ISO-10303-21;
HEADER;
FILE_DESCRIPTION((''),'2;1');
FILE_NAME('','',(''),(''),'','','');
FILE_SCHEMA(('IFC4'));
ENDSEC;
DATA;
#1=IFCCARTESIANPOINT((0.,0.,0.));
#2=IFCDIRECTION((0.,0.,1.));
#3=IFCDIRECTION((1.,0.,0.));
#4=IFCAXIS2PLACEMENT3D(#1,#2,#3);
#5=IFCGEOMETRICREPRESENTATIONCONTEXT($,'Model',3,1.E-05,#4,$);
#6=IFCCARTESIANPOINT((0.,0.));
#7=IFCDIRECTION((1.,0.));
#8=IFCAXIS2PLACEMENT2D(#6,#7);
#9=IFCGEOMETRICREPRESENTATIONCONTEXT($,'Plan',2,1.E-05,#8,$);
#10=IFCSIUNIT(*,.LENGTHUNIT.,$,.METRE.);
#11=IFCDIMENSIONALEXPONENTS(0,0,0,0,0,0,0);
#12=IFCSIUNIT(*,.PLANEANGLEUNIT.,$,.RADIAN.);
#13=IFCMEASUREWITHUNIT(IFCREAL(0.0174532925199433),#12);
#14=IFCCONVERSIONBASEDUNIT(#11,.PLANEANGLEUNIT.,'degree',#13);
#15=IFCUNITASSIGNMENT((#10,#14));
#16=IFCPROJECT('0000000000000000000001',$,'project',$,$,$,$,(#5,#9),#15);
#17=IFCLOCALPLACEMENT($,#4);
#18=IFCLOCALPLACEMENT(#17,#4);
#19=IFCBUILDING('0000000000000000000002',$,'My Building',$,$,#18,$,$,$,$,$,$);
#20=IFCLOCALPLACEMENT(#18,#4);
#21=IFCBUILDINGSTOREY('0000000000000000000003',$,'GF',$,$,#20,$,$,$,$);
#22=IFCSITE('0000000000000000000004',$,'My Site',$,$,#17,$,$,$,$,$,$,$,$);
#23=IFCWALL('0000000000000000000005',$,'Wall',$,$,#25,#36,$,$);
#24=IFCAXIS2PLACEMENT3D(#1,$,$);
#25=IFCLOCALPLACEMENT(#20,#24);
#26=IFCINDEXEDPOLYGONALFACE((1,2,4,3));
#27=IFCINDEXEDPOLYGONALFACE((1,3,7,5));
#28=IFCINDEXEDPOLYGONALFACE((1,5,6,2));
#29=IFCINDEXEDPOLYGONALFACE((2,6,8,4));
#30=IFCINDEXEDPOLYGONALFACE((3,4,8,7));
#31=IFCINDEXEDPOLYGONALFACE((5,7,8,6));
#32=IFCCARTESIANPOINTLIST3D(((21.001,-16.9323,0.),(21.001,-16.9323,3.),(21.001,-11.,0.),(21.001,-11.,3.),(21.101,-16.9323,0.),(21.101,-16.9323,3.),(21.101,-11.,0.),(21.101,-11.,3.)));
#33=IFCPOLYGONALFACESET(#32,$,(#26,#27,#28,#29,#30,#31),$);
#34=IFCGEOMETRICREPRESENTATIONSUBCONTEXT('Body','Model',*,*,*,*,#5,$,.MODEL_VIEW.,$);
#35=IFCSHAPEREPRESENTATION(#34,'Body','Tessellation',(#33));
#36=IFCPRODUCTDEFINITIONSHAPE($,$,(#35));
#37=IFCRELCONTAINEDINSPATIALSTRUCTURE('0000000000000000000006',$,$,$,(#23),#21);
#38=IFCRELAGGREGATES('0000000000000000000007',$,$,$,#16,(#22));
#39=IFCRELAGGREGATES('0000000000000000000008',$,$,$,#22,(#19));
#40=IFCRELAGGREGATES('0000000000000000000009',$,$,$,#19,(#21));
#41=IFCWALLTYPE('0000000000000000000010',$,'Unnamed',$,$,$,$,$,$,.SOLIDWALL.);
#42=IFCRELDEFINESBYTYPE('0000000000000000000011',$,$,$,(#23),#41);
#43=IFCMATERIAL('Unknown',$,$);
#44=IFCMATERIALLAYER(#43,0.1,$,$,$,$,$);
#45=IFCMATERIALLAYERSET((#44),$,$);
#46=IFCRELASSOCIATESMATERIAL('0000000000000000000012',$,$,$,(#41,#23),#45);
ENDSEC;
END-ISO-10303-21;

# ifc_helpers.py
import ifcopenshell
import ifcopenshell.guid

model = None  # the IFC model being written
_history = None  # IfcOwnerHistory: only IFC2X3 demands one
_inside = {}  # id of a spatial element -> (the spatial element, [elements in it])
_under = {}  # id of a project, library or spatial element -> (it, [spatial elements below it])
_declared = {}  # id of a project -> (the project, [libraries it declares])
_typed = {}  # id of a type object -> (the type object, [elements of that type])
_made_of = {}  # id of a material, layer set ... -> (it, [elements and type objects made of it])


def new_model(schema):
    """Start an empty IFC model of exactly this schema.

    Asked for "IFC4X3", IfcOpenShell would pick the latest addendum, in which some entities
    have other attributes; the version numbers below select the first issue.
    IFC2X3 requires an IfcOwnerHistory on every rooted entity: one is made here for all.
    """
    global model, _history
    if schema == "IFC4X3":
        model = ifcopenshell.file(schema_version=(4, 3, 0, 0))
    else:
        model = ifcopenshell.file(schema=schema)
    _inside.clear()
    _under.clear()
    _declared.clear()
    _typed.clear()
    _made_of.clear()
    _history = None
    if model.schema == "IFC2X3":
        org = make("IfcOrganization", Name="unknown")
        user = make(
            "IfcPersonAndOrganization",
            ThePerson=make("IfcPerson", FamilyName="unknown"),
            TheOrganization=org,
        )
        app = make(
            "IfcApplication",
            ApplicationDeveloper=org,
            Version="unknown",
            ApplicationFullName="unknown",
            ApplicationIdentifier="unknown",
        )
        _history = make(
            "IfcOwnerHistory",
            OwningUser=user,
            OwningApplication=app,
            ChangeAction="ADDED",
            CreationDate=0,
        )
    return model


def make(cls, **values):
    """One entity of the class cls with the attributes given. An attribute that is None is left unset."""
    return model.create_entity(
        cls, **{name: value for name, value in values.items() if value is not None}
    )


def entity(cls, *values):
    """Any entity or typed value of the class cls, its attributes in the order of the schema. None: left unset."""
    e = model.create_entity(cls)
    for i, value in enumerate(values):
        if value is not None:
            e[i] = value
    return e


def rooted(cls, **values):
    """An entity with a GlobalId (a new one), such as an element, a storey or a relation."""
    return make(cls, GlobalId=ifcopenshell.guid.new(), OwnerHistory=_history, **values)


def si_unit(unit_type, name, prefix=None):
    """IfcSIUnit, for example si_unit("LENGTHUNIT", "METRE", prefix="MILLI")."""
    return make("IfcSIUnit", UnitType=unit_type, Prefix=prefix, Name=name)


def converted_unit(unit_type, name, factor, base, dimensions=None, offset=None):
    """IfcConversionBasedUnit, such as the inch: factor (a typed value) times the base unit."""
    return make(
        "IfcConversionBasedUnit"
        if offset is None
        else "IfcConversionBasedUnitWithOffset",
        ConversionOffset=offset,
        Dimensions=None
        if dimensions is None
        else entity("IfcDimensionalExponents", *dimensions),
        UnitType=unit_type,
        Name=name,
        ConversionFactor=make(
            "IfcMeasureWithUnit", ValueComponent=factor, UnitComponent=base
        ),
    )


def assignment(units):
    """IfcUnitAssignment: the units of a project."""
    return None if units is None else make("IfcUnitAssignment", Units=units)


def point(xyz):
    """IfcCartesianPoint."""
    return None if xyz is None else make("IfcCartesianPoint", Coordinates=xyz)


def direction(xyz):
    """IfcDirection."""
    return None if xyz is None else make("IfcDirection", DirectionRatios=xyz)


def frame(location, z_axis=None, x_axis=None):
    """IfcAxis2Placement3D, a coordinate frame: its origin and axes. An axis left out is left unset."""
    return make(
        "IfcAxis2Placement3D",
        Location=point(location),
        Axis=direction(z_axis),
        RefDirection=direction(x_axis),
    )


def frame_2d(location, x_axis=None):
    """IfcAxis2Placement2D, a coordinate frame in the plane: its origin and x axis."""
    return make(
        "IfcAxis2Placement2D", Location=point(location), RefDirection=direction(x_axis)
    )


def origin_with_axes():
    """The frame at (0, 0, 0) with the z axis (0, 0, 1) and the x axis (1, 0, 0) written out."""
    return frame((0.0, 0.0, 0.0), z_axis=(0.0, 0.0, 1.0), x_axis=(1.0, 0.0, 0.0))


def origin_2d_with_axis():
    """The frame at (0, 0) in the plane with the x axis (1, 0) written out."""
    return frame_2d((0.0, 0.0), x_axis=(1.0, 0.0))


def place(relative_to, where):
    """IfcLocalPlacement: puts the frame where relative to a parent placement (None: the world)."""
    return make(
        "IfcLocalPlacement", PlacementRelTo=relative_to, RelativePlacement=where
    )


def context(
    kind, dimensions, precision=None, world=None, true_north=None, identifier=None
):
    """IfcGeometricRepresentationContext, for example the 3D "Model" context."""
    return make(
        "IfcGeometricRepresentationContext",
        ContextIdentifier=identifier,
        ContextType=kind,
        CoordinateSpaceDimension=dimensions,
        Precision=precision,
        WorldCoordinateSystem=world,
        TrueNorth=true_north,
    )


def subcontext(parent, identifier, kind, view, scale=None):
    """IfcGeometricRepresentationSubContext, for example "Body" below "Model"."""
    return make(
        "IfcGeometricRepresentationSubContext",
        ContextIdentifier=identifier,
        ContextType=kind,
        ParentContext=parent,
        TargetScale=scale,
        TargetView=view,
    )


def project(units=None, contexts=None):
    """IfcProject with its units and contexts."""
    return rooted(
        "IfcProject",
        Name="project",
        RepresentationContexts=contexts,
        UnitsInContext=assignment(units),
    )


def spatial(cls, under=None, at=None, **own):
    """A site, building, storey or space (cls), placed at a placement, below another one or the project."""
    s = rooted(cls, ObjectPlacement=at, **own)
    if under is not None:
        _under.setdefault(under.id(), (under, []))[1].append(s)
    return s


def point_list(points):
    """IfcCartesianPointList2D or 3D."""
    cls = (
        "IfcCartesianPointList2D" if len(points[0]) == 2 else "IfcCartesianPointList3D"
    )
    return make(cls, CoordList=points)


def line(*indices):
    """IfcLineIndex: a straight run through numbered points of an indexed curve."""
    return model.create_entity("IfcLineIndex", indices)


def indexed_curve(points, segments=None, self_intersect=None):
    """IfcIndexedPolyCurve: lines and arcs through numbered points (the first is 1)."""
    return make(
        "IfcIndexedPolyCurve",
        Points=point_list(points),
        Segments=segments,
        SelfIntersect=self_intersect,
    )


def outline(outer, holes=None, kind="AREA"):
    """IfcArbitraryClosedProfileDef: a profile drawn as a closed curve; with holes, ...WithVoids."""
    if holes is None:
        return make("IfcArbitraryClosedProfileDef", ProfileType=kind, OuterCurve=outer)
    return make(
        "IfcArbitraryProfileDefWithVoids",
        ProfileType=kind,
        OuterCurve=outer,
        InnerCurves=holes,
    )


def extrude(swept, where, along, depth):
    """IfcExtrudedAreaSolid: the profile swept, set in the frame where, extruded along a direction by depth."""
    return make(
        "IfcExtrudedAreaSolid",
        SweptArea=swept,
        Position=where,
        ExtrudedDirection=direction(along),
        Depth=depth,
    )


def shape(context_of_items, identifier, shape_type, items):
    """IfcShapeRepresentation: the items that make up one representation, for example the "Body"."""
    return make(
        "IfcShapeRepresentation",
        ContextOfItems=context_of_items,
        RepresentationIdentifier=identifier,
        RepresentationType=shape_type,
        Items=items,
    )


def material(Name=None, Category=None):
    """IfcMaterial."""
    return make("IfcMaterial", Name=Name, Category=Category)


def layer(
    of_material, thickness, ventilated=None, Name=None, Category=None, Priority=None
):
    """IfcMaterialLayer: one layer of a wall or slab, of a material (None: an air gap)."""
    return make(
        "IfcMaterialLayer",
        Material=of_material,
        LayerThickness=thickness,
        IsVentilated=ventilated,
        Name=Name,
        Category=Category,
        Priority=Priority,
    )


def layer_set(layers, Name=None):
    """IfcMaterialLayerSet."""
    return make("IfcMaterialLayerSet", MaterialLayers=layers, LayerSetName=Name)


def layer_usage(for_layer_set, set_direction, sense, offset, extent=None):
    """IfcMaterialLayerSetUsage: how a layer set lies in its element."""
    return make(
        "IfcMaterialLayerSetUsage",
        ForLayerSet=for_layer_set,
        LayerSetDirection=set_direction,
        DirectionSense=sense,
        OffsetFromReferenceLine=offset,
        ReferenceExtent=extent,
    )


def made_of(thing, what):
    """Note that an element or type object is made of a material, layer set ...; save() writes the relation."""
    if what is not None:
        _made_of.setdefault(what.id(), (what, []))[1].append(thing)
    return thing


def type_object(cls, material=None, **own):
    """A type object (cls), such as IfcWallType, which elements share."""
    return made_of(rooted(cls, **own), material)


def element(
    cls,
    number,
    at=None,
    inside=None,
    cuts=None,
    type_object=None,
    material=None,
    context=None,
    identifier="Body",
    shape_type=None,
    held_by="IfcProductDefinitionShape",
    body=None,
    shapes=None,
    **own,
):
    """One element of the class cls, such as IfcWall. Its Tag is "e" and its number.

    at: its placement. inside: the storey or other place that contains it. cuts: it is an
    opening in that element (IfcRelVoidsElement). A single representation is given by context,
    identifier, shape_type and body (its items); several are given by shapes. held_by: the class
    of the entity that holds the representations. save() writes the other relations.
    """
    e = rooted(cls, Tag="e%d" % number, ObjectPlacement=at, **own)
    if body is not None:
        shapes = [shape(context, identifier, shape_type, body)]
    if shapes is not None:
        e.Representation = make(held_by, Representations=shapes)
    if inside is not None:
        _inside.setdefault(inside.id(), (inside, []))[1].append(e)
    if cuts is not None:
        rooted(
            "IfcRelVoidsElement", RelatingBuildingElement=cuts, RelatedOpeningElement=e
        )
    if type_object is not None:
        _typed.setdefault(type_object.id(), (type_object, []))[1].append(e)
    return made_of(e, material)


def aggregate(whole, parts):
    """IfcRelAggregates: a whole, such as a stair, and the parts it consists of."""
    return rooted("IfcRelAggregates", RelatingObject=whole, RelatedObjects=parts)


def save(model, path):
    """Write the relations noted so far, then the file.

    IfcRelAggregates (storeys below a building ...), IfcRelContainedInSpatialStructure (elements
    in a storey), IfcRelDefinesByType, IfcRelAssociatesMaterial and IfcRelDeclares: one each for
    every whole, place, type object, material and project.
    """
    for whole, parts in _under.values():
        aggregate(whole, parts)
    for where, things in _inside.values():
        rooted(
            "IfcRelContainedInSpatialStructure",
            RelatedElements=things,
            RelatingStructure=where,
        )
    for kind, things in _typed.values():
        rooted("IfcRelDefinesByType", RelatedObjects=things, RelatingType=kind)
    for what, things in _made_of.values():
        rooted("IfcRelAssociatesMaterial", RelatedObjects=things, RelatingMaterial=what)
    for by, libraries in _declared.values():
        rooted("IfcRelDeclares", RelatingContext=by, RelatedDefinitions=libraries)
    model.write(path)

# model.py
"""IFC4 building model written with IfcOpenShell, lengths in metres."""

from ifc_helpers import new_model, entity, si_unit, converted_unit, frame, origin_with_axes, origin_2d_with_axis, place, context, subcontext, project, spatial, line, indexed_curve, outline, extrude, material, layer, layer_set, layer_usage, type_object, element, save


model = new_model("IFC4")

# Units and contexts
model_context = context("Model", 3, precision=1e-05, world=origin_with_axes())
plan_context = context("Plan", 2, precision=1e-05, world=origin_2d_with_axis())
body_context_1 = subcontext(model_context, "Body", "Model", "MODEL_VIEW")
ifc_project = project(units=[si_unit("LENGTHUNIT", "METRE"), converted_unit("PLANEANGLEUNIT", "degree", entity("IfcReal", 0.0174532925199433), si_unit("PLANEANGLEUNIT", "RADIAN"), dimensions=[0, 0, 0, 0, 0, 0, 0])], contexts=[model_context, plan_context])

# Site, building, storey
site_placement = place(None, origin_with_axes())
site = spatial("IfcSite", under=ifc_project, at=site_placement, Name="My Site")
building_placement = place(site_placement, origin_with_axes())
building = spatial("IfcBuilding", under=site, at=building_placement, Name="My Building")
storey_placement = place(building_placement, origin_with_axes())
storey = spatial("IfcBuildingStorey", under=building, at=storey_placement, Name="GF")

# Shared definitions
ifc_material = material(Name="Unknown")
ifc_layer = layer(ifc_material, 0.1)
ifc_layer_set = layer_set([ifc_layer])
wall_type = type_object("IfcWallType", Name="Unnamed", PredefinedType="SOLIDWALL", material=ifc_layer_set)

# Wall
ifc_layer_usage_1 = layer_usage(ifc_layer_set, "AXIS2", "POSITIVE", 0.0)
wall_1_placement = place(storey_placement, frame((21.101, -16.9323, 0.0), z_axis=(0.0, 0.0, 1.0), x_axis=(0.0, 1.0, 0.0)))
element("IfcWall", 1, at=wall_1_placement, inside=storey, type_object=wall_type, material=ifc_layer_usage_1, Name="Wall", context=body_context_1, shape_type="SweptSolid", body=[
    extrude(outline(indexed_curve([(0.0, 0.0), (0.0, 0.1), (5.9323, 0.1), (5.9323, 0.0)], segments=[line(1, 2, 3, 4, 1)])), origin_with_axes(), (0.0, 0.0, 1.0), 3.0),
])

save(model, "model.ifc")
